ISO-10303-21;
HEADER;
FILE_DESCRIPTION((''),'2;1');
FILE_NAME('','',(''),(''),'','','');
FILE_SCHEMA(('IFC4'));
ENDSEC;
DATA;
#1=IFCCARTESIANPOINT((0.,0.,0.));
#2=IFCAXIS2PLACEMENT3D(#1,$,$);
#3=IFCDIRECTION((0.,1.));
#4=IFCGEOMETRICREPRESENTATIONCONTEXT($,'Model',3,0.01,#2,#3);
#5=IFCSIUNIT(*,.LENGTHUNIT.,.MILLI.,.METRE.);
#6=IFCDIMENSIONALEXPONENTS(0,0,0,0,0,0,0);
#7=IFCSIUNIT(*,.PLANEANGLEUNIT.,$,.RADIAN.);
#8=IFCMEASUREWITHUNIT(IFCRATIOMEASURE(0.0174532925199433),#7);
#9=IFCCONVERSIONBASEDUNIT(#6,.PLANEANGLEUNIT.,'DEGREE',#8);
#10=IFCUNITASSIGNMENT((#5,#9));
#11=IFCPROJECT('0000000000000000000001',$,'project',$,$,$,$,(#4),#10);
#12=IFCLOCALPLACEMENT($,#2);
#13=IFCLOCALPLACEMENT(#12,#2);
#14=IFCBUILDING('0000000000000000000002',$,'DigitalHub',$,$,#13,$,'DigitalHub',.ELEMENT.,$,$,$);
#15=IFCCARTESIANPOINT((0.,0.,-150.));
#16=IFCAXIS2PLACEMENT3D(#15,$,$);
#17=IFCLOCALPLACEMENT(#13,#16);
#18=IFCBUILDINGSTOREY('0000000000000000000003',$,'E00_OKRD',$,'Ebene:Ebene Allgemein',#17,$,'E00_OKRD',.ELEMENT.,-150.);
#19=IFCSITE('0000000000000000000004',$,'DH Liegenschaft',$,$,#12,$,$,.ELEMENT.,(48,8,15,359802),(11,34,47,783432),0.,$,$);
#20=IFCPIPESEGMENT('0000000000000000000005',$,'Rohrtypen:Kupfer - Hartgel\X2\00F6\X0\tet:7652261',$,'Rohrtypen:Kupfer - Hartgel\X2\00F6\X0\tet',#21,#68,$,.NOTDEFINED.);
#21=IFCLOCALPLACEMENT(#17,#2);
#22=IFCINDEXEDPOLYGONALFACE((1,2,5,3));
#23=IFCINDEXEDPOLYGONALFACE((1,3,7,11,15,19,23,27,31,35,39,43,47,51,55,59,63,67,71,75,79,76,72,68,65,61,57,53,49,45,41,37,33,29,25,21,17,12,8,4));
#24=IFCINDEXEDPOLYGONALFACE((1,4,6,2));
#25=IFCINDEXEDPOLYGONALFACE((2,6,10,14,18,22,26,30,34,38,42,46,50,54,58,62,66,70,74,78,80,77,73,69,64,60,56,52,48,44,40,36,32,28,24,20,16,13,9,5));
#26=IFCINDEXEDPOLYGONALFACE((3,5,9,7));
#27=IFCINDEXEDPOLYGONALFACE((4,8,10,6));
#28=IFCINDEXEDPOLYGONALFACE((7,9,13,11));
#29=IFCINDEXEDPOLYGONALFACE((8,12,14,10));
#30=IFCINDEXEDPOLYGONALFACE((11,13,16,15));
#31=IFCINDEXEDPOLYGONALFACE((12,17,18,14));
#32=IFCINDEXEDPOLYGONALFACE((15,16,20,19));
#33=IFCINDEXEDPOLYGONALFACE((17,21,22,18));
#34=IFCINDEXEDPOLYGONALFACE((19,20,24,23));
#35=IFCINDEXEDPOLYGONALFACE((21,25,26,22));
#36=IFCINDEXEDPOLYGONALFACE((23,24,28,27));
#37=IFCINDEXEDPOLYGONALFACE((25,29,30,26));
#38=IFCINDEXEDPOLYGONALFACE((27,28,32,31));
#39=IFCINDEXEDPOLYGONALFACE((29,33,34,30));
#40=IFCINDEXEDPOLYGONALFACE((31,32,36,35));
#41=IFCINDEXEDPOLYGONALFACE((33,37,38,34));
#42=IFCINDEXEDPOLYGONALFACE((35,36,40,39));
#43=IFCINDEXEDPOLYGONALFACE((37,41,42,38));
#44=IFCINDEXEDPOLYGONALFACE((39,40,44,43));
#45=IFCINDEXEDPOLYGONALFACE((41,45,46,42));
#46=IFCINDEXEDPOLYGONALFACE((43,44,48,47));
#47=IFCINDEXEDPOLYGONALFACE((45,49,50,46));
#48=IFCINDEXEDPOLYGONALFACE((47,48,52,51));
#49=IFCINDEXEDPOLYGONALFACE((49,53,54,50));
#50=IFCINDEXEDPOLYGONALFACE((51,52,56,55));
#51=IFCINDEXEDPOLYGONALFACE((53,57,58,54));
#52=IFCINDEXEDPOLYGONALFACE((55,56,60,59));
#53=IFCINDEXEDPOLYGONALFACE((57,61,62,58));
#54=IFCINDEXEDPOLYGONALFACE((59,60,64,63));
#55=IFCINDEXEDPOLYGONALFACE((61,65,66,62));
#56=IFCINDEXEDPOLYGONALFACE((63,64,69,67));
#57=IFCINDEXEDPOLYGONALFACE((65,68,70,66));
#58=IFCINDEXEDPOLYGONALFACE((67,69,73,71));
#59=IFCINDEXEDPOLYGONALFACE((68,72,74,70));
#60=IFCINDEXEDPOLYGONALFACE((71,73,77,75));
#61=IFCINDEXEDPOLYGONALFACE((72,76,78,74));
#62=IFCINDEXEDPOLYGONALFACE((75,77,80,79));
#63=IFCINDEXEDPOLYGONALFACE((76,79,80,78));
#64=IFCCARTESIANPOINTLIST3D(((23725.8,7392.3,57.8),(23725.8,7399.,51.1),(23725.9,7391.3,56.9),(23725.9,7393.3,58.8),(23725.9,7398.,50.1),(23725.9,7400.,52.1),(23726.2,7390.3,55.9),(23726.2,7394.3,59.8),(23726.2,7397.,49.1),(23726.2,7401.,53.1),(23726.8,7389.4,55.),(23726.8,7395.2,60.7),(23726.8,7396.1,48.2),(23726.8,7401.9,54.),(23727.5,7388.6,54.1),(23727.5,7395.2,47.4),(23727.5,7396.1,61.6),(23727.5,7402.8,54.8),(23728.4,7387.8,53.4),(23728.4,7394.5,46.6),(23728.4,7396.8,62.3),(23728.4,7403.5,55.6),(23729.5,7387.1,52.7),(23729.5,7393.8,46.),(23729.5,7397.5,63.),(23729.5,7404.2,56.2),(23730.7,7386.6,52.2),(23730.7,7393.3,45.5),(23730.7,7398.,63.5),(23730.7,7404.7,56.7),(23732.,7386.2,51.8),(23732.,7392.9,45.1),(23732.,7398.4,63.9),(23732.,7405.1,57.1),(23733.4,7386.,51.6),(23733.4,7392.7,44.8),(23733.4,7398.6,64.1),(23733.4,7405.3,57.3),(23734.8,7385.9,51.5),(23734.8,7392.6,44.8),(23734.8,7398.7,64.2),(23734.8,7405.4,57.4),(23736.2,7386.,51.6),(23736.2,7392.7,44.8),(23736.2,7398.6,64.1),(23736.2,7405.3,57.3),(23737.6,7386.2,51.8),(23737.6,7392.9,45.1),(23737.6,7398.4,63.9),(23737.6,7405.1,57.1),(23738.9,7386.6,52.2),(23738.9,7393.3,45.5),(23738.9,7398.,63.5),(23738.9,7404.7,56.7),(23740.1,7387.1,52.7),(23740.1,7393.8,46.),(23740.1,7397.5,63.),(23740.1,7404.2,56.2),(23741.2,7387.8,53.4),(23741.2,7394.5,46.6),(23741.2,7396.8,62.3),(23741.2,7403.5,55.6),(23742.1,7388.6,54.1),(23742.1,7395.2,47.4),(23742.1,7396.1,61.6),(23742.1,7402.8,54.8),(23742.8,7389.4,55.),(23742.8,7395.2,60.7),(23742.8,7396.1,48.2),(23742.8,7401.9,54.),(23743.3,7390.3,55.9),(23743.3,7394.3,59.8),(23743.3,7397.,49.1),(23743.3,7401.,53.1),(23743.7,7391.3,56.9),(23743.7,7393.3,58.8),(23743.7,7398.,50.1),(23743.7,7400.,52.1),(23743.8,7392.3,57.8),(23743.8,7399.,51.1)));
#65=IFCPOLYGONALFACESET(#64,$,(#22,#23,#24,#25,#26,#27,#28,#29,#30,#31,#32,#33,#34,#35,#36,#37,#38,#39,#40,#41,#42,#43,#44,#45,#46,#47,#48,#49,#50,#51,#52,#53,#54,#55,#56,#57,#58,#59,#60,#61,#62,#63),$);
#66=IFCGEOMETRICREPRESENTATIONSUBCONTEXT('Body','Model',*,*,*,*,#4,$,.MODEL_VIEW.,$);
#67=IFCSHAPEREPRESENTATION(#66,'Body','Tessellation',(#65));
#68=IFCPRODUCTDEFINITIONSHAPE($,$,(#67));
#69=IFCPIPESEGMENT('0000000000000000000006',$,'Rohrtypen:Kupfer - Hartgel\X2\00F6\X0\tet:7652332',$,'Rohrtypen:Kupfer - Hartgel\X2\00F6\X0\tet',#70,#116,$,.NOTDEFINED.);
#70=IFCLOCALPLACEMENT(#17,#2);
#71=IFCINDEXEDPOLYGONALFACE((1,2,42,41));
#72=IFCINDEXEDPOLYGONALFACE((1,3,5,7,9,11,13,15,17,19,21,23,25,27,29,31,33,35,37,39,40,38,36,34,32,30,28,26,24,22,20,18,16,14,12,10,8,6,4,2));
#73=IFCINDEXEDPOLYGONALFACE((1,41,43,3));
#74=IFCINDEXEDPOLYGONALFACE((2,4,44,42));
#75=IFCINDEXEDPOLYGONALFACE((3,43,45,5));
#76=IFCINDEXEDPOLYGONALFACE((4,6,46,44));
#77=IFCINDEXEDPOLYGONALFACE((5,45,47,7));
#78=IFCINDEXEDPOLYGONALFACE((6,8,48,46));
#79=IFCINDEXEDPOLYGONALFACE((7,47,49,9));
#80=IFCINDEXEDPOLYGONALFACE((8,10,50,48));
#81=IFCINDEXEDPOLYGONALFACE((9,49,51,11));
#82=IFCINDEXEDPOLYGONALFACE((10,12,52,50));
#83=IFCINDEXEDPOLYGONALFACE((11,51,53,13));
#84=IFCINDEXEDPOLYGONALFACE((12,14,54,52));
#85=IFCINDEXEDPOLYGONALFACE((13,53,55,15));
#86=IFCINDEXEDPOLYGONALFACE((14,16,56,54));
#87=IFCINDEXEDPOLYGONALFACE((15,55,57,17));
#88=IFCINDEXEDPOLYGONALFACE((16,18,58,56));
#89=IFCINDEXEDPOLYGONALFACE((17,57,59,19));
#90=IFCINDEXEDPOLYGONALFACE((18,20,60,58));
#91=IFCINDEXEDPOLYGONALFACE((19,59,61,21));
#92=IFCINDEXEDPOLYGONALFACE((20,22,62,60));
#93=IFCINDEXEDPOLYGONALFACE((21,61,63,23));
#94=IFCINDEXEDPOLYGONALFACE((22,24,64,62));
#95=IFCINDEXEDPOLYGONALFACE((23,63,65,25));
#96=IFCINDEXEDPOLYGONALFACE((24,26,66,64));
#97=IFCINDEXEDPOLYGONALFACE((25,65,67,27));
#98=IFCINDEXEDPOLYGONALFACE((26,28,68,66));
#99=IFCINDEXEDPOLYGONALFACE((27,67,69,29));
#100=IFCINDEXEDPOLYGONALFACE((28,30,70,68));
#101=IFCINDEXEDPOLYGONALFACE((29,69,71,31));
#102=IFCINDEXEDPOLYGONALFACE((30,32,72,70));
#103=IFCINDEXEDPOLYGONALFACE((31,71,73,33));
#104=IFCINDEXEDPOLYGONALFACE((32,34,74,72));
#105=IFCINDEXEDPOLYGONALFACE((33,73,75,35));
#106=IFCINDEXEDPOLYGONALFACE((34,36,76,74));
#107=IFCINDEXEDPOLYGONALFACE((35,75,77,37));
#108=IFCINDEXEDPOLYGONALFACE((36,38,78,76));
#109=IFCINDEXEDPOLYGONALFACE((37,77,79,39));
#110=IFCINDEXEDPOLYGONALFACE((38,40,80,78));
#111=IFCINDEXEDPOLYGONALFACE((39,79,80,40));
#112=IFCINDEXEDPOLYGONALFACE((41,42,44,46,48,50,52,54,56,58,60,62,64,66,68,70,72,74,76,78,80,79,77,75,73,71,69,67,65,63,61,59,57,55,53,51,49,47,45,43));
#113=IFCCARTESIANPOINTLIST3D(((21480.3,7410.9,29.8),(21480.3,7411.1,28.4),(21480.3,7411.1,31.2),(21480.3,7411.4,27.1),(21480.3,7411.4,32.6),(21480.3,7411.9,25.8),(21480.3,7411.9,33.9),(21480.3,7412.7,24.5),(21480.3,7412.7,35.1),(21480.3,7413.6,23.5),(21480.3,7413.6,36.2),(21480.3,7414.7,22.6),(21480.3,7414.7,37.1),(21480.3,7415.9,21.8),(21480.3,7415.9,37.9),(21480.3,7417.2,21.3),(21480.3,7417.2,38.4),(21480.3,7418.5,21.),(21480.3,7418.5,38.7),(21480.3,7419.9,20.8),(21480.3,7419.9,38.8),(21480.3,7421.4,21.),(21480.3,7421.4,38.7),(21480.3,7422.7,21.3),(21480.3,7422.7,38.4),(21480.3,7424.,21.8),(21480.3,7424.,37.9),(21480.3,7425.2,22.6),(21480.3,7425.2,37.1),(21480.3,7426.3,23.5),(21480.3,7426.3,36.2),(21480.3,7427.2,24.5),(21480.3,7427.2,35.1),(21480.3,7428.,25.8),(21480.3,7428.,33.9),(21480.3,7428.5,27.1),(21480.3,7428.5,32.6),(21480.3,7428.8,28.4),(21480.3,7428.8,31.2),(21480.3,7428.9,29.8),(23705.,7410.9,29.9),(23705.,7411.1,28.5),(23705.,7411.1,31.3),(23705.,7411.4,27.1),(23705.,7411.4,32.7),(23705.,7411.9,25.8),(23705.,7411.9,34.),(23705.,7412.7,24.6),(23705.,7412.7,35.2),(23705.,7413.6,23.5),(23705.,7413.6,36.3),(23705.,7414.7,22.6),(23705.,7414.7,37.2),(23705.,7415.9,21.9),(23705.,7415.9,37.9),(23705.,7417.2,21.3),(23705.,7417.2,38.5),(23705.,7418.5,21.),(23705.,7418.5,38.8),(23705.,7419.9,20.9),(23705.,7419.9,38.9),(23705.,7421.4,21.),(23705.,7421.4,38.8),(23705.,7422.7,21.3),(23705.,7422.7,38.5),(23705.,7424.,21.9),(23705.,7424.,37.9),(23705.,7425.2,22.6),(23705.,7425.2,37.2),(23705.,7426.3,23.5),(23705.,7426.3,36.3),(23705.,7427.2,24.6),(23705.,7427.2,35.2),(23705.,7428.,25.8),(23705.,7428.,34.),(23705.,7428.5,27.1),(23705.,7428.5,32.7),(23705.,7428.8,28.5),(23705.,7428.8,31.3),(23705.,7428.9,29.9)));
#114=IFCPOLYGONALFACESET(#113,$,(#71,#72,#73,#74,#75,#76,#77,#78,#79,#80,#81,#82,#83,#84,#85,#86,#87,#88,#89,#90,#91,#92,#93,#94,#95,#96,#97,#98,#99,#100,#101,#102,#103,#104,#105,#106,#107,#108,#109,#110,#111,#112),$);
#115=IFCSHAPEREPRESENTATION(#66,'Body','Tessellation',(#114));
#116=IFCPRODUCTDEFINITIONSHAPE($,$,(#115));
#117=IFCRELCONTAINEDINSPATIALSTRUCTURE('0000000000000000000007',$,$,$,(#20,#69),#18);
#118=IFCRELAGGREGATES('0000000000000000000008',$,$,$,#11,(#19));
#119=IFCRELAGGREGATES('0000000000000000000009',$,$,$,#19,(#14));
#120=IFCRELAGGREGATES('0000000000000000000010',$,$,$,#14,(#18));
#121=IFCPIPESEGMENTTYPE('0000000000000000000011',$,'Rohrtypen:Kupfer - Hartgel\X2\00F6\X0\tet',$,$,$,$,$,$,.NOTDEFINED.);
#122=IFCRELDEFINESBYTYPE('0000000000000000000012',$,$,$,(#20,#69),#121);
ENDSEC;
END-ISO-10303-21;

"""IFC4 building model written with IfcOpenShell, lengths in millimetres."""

from ifc_helpers import new_model, entity, si_unit, converted_unit, direction, frame, origin, place, context, subcontext, project, spatial, indexed_curve, outline, extrude, type_object, element, save


model = new_model("IFC4")

# Units and contexts
model_context = context("Model", 3, precision=0.01, world=origin(), true_north=direction((0.0, 1.0)))
body_context = subcontext(model_context, "Body", "Model", "MODEL_VIEW")
ifc_project = project(units=[si_unit("LENGTHUNIT", "METRE", prefix="MILLI"), converted_unit("PLANEANGLEUNIT", "DEGREE", entity("IfcRatioMeasure", 0.0174532925199433), si_unit("PLANEANGLEUNIT", "RADIAN"), dimensions=[0, 0, 0, 0, 0, 0, 0])], contexts=[model_context])

# Site, building, storey
site_placement = place(None, origin())
site = spatial("IfcSite", under=ifc_project, at=site_placement, Name="DH Liegenschaft", CompositionType="ELEMENT", RefLatitude=(48, 8, 15, 359802), RefLongitude=(11, 34, 47, 783432), RefElevation=0.0)
building_placement = place(site_placement, origin())
building = spatial("IfcBuilding", under=site, at=building_placement, Name="DigitalHub", LongName="DigitalHub", CompositionType="ELEMENT")
storey_placement = place(building_placement, frame((0.0, 0.0, -150.0)))
storey = spatial("IfcBuildingStorey", under=building, at=storey_placement, Name="E00_OKRD", ObjectType="Ebene:Ebene Allgemein", LongName="E00_OKRD", CompositionType="ELEMENT", Elevation=-150.0)

# Pipe segments
pipe_segment_type = type_object("IfcPipeSegmentType", Name="Rohrtypen:Kupfer - Hartgelötet", PredefinedType="NOTDEFINED")
pipe_segment_1_placement = place(storey_placement, frame((23724.2, 7384.3, 43.2)))
element("IfcPipeSegment", 1, at=pipe_segment_1_placement, inside=storey, type_object=pipe_segment_type, Name="Rohrtypen:Kupfer - Hartgelötet:7652261", ObjectType="Rohrtypen:Kupfer - Hartgelötet", PredefinedType="NOTDEFINED", context=body_context, shape_type="SweptSolid", body=[
    extrude(outline(indexed_curve([(9.0, 0.0), (8.9, 1.4), (8.6, 2.8), (8.0, 4.1), (7.3, 5.3), (6.4, 6.4), (5.3, 7.3), (4.1, 8.0), (2.8, 8.6), (1.4, 8.9), (0.0, 9.0), (-1.4, 8.9), (-2.8, 8.6), (-4.1, 8.0), (-5.3, 7.3), (-6.4, 6.4), (-7.3, 5.3), (-8.0, 4.1), (-8.6, 2.8), (-8.9, 1.4), (-9.0, 0.0), (-8.9, -1.4), (-8.6, -2.8), (-8.0, -4.1), (-7.3, -5.3), (-6.4, -6.4), (-5.3, -7.3), (-4.1, -8.0), (-2.8, -8.6), (-1.4, -8.9), (0.0, -9.0), (1.4, -8.9), (2.8, -8.6), (4.1, -8.0), (5.3, -7.3), (6.4, -6.4), (7.3, -5.3), (8.0, -4.1), (8.6, -2.8), (8.9, -1.4), (9.0, 0.0)], self_intersect=False)), frame((10.6, 14.7, 7.9), z_axis=(0.0, -0.703461, 0.710734), x_axis=(-1.0, 0.0, 0.0)), (0.0, 0.0, 1.0), 9.5),
])
pipe_segment_2_placement = place(storey_placement, frame((21480.3, 7409.3, 19.2)))
element("IfcPipeSegment", 2, at=pipe_segment_2_placement, inside=storey, type_object=pipe_segment_type, Name="Rohrtypen:Kupfer - Hartgelötet:7652332", ObjectType="Rohrtypen:Kupfer - Hartgelötet", PredefinedType="NOTDEFINED", context=body_context, shape_type="SweptSolid", body=[
    extrude(outline(indexed_curve([(9.0, 0.0), (8.9, 1.4), (8.6, 2.8), (8.0, 4.1), (7.3, 5.3), (6.4, 6.4), (5.3, 7.3), (4.1, 8.0), (2.8, 8.6), (1.4, 8.9), (0.0, 9.0), (-1.4, 8.9), (-2.8, 8.6), (-4.1, 8.0), (-5.3, 7.3), (-6.4, 6.4), (-7.3, 5.3), (-8.0, 4.1), (-8.6, 2.8), (-8.9, 1.4), (-9.0, 0.0), (-8.9, -1.4), (-8.6, -2.8), (-8.0, -4.1), (-7.3, -5.3), (-6.4, -6.4), (-5.3, -7.3), (-4.1, -8.0), (-2.8, -8.6), (-1.4, -8.9), (0.0, -9.0), (1.4, -8.9), (2.8, -8.6), (4.1, -8.0), (5.3, -7.3), (6.4, -6.4), (7.3, -5.3), (8.0, -4.1), (8.6, -2.8), (8.9, -1.4), (9.0, 0.0)], self_intersect=False)), frame((0.0, 10.6, 10.6), z_axis=(1.0, 0.0, 0.000027), x_axis=(0.0, -1.0, 0.0)), (0.0, 0.0, 1.0), 2224.7),
])

save(model, "model.ifc")
